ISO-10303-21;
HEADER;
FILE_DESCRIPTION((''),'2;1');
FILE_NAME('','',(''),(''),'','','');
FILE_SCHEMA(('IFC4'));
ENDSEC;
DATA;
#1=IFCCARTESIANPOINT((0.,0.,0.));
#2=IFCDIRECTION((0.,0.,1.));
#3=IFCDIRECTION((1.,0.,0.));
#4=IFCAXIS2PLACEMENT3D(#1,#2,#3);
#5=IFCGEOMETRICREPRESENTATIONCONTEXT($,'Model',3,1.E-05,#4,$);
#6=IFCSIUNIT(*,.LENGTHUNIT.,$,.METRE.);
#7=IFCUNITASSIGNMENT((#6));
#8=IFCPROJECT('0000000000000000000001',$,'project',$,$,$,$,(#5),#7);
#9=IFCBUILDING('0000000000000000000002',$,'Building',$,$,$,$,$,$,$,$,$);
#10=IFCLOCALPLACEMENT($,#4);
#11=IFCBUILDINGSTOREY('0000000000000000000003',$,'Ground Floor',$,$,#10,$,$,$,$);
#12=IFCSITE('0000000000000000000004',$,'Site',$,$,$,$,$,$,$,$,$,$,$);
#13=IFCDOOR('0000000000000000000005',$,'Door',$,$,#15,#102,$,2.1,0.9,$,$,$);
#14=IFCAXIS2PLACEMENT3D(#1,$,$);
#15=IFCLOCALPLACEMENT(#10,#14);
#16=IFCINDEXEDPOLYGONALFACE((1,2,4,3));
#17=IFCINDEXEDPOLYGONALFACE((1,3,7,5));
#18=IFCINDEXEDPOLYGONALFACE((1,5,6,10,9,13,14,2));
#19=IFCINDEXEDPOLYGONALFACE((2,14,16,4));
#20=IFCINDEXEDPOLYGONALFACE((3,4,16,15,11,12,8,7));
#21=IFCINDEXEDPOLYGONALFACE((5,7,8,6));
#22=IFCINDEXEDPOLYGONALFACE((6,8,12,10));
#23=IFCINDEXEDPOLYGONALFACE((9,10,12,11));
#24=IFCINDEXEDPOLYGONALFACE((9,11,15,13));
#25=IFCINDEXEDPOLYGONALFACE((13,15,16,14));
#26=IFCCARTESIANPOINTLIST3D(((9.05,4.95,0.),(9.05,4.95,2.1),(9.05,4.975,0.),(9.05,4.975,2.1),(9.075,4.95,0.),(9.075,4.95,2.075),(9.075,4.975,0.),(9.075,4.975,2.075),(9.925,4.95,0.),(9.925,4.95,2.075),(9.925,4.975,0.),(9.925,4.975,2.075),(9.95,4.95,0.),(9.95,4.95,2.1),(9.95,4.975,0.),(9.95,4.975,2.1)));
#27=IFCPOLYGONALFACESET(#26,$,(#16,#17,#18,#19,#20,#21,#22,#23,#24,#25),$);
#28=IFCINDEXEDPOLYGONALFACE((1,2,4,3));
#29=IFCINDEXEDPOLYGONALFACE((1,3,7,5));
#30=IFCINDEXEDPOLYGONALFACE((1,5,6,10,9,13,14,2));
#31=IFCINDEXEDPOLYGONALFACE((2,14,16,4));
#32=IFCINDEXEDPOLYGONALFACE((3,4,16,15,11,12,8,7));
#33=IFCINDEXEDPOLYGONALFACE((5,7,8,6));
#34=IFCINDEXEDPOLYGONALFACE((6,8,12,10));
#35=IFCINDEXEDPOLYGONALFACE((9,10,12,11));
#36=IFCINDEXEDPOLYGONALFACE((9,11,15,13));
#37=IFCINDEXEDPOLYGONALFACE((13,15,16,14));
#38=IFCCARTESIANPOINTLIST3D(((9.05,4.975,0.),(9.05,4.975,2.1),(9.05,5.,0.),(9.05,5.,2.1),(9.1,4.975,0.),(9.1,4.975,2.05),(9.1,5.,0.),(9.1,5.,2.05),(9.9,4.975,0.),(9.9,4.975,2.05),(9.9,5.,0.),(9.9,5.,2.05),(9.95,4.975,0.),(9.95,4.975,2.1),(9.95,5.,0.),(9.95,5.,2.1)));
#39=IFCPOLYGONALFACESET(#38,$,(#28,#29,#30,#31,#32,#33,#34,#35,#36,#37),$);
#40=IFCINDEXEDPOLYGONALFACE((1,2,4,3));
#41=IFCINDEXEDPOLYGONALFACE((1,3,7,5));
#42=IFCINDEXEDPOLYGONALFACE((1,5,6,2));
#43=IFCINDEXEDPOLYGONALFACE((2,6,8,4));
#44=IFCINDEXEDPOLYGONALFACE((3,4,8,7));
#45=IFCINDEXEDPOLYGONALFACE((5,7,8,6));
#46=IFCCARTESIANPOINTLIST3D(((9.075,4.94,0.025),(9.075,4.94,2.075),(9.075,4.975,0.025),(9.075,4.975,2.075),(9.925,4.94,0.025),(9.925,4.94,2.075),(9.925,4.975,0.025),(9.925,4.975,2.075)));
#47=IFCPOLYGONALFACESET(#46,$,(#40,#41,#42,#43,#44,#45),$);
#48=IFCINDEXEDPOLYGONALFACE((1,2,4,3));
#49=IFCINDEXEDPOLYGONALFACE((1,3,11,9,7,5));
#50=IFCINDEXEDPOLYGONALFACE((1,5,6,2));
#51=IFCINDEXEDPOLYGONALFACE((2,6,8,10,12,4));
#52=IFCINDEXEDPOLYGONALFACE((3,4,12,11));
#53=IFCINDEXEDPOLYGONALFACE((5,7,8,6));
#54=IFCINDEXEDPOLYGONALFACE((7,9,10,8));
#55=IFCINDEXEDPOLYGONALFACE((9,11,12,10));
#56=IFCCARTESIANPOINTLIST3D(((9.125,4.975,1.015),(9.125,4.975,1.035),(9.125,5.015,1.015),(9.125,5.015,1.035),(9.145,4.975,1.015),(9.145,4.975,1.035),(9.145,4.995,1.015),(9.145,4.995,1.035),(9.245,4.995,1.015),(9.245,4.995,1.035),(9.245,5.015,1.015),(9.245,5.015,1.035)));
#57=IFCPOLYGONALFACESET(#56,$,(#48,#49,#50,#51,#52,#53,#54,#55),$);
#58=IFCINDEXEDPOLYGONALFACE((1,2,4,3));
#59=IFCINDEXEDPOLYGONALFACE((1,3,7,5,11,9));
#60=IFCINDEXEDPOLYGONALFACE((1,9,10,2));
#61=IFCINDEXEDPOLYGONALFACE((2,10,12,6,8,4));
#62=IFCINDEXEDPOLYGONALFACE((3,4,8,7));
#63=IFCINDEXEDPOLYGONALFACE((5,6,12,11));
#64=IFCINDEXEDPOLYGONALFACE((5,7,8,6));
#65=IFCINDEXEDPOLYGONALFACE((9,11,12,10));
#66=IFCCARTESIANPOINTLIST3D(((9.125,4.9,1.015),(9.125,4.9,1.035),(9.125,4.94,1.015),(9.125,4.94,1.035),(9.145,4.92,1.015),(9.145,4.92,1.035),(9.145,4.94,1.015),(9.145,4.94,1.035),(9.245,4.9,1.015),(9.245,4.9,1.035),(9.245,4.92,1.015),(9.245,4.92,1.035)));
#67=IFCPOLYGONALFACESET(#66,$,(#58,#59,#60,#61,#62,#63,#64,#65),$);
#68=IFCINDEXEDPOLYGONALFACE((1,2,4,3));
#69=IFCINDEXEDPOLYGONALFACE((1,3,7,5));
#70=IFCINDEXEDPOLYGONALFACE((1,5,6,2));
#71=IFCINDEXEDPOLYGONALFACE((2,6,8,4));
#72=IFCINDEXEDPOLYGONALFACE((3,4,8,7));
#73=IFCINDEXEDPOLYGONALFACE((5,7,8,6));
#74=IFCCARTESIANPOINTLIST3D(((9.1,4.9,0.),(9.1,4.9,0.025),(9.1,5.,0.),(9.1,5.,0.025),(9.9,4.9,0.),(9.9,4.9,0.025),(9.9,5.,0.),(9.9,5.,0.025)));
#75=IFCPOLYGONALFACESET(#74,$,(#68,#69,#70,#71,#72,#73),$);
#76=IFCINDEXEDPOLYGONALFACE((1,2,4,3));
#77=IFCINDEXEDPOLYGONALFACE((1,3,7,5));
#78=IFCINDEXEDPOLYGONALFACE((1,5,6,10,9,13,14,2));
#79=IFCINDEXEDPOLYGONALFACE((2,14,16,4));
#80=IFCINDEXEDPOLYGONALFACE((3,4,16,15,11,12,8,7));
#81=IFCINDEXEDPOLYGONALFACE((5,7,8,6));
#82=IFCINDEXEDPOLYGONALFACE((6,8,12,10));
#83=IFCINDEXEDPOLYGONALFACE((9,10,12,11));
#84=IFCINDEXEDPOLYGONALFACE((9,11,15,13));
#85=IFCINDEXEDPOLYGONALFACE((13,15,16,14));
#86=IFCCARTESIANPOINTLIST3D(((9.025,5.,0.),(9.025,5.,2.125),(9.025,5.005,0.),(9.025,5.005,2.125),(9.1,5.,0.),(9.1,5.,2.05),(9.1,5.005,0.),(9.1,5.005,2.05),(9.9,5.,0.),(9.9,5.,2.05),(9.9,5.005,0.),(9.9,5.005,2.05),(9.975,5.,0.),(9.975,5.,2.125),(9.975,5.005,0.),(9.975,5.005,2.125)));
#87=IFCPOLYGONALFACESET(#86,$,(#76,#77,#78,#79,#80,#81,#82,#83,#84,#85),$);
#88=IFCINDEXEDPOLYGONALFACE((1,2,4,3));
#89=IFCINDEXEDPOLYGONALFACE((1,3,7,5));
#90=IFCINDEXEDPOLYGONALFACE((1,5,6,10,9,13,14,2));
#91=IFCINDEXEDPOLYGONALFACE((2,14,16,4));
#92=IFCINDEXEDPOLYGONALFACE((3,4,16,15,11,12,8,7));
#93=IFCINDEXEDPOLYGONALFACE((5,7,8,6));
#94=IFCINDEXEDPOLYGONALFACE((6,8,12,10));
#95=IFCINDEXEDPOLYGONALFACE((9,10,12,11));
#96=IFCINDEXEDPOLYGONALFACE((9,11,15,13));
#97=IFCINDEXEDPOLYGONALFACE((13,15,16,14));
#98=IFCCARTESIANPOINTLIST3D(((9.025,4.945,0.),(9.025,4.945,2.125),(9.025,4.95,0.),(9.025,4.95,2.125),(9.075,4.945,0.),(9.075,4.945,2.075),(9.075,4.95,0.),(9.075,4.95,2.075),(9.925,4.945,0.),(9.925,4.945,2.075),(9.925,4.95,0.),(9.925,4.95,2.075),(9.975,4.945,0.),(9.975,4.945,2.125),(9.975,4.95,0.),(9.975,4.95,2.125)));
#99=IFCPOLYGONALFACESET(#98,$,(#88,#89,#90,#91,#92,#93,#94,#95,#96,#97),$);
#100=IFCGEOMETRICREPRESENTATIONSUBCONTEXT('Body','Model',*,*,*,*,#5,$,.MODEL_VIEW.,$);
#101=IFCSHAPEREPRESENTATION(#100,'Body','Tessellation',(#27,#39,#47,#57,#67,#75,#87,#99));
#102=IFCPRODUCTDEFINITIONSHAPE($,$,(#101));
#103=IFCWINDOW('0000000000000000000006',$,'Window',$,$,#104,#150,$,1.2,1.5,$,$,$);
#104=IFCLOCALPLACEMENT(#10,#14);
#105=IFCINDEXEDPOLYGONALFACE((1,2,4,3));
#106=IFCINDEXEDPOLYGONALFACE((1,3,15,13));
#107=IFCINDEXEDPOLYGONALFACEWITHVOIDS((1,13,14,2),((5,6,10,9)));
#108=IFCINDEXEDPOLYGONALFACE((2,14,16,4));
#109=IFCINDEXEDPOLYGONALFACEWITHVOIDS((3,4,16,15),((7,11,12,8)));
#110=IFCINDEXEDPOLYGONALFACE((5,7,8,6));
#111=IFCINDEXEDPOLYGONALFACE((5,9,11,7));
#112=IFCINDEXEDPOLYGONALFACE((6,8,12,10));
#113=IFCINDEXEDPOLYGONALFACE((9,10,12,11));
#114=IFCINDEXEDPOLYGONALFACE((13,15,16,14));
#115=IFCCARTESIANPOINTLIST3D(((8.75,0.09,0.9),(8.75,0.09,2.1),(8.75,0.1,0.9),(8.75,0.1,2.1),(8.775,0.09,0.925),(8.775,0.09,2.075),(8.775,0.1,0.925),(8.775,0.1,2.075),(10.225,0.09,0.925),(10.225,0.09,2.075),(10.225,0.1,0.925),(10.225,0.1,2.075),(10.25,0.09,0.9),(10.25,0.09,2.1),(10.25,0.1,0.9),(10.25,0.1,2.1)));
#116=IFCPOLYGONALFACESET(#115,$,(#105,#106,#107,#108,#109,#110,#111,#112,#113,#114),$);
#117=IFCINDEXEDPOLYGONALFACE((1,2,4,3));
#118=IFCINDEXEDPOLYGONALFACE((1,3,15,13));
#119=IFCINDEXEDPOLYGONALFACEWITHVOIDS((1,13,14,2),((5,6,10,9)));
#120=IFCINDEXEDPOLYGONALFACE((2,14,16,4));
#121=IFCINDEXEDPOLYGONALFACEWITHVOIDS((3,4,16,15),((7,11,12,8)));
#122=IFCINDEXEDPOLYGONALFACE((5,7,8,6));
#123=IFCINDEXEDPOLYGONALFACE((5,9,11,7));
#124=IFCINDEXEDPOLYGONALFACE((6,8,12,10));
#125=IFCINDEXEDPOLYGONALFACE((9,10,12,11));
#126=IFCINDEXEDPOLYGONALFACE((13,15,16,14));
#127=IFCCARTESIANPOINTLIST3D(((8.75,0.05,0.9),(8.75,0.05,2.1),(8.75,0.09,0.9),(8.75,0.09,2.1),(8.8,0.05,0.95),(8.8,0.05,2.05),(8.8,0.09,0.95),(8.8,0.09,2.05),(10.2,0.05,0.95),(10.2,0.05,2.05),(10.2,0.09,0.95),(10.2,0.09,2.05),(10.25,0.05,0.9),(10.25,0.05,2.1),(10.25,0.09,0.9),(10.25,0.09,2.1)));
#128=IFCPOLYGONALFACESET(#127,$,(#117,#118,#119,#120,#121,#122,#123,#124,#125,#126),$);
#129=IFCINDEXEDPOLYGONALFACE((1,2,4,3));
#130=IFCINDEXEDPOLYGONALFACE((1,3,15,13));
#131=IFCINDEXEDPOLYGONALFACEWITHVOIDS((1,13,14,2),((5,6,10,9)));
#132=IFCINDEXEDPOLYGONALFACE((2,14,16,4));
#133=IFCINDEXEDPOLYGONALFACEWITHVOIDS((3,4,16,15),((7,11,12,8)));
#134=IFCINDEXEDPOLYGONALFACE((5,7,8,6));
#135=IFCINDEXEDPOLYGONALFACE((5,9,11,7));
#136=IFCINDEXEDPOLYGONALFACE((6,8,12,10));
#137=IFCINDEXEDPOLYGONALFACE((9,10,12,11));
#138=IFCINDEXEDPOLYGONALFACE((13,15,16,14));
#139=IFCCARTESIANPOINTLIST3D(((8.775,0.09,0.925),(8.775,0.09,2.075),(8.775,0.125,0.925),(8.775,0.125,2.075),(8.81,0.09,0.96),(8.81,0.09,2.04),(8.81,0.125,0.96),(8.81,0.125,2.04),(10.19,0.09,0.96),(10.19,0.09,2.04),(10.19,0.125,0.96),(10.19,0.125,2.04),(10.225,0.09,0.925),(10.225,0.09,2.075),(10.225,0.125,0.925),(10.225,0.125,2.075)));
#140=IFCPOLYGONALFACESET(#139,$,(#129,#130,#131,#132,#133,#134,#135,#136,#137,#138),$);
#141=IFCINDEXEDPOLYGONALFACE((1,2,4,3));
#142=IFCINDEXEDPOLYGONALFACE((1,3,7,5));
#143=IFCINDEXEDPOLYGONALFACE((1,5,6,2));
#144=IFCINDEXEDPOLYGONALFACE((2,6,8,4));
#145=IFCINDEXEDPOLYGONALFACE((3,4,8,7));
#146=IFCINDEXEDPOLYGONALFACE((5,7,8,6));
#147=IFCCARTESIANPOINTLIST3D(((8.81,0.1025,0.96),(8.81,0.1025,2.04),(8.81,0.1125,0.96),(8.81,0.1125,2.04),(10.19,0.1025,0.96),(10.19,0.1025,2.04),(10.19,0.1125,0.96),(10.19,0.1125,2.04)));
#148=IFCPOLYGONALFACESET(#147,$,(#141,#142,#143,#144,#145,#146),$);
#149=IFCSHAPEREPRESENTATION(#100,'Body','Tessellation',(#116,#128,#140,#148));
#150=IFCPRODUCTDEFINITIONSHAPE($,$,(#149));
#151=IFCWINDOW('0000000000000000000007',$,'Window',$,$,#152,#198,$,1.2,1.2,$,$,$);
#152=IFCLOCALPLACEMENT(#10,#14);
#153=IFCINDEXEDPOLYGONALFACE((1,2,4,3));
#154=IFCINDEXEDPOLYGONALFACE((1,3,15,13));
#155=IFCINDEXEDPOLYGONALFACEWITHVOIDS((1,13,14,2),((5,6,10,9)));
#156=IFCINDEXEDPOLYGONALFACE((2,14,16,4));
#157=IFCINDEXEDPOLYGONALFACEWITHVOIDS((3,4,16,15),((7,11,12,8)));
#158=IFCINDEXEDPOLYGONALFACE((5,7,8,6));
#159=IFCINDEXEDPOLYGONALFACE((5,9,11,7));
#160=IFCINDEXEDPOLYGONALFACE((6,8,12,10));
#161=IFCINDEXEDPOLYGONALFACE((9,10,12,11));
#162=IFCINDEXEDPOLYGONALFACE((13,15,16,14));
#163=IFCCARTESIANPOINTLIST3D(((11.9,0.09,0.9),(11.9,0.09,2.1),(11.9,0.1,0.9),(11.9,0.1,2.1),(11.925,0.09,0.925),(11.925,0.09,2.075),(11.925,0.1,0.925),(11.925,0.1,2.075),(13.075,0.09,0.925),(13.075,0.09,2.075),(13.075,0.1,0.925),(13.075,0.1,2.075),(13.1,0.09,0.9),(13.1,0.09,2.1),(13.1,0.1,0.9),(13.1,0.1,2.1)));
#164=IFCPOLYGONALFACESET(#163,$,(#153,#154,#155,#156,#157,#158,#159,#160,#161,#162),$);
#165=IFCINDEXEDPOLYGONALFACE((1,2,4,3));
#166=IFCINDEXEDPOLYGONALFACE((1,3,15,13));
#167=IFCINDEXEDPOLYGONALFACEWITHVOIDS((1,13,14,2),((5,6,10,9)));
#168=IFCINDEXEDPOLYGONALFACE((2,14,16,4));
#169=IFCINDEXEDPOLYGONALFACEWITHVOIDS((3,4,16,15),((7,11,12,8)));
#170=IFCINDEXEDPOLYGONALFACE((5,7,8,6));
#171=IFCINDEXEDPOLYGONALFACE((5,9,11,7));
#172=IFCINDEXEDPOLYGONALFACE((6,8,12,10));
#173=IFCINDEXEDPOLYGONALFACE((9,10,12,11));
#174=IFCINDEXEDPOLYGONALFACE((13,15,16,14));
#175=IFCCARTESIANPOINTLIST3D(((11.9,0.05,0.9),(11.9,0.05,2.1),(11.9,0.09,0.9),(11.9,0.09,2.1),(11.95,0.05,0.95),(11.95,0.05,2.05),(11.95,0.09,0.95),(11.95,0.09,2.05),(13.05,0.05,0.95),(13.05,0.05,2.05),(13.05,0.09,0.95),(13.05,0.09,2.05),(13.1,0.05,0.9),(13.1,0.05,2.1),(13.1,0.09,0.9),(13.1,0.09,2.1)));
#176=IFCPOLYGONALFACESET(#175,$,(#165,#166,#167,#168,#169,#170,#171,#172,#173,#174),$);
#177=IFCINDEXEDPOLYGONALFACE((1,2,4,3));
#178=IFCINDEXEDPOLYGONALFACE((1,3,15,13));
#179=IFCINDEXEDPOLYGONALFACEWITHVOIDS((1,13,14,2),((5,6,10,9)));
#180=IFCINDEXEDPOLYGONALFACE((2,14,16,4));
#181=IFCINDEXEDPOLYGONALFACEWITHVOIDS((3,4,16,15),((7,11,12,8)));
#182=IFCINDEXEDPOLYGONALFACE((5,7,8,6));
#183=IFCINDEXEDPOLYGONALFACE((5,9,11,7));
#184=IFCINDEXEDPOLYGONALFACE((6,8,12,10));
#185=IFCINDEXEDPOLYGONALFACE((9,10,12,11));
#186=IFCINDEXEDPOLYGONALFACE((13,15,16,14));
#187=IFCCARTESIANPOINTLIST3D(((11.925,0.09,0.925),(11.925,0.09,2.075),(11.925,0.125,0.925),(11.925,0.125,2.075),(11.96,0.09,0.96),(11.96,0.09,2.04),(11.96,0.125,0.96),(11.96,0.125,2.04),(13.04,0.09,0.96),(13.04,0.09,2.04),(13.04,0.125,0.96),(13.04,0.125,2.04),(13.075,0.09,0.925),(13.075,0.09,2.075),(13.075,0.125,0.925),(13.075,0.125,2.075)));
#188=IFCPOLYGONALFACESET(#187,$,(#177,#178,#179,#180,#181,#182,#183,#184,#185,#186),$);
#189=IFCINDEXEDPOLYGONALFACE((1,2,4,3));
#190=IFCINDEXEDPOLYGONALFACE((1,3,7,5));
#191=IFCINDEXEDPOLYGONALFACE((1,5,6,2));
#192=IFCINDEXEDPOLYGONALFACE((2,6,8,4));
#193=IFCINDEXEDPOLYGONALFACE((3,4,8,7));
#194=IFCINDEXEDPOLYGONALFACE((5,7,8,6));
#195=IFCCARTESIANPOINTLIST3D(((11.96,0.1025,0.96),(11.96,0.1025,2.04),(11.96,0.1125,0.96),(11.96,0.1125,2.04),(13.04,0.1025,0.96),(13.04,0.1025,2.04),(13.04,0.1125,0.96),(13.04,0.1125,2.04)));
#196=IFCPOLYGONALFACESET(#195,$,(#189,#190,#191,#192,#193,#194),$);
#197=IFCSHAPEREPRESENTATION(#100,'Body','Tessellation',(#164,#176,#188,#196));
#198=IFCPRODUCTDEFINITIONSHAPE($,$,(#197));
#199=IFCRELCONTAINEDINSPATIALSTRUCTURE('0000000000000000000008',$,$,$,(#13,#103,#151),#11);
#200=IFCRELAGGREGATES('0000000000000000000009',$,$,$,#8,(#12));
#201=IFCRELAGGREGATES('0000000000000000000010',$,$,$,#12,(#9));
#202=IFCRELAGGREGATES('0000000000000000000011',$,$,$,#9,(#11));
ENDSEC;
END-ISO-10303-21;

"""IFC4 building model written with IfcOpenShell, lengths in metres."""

from ifc_helpers import new_model, si_unit, frame, origin_with_axes, place, context, subcontext, project, spatial, line, indexed_curve, outline, extrude, element, save


model = new_model("IFC4")

# Units and contexts
model_context = context("Model", 3, precision=1e-05, world=origin_with_axes())
body_context = subcontext(model_context, "Body", "Model", "MODEL_VIEW")
ifc_project = project(units=[si_unit("LENGTHUNIT", "METRE")], contexts=[model_context])

# Site, building, storey
site = spatial("IfcSite", under=ifc_project, Name="Site")
building = spatial("IfcBuilding", under=site, Name="Building")
storey_placement = place(None, origin_with_axes())
storey = spatial("IfcBuildingStorey", under=building, at=storey_placement, Name="Ground Floor")

# Door
door_1_placement = place(storey_placement, frame((9.95, 5.0, 0.0), z_axis=(0.0, 0.0, 1.0), x_axis=(-1.0, 0.0, 0.0)))
element("IfcDoor", 1, at=door_1_placement, inside=storey, Name="Door", OverallHeight=2.1, OverallWidth=0.9, context=body_context, shape_type="SweptSolid", body=[
    extrude(outline(indexed_curve([(0.0, 0.0), (0.0, 2.1), (0.9, 2.1), (0.9, 0.0), (0.875, 0.0), (0.875, 2.075), (0.025, 2.075), (0.025, 0.0)], segments=[line(1, 2, 3, 4, 5, 6, 7, 8, 1)])), frame((0.0, 0.025, 0.0), z_axis=(0.0, -1.0, 0.0), x_axis=(1.0, 0.0, 0.0)), (0.0, 0.0, -1.0), 0.025),
    extrude(outline(indexed_curve([(0.0, 0.0), (0.0, 2.1), (0.9, 2.1), (0.9, 0.0), (0.85, 0.0), (0.85, 2.05), (0.05, 2.05), (0.05, 0.0)], segments=[line(1, 2, 3, 4, 5, 6, 7, 8, 1)])), frame((0.0, 0.0, 0.0), z_axis=(0.0, -1.0, 0.0), x_axis=(1.0, 0.0, 0.0)), (0.0, 0.0, -1.0), 0.025),
    extrude(outline(indexed_curve([(0.0, 0.0), (0.85, 0.0), (0.85, 0.035), (0.0, 0.035)], segments=[line(1, 2, 3, 4, 1)])), frame((0.025, 0.025, 0.025), z_axis=(0.0, 0.0, 1.0), x_axis=(1.0, 0.0, 0.0)), (0.0, 0.0, 1.0), 2.05),
    extrude(outline(indexed_curve([(0.0, 0.0), (0.0, -0.04), (-0.12, -0.04), (-0.12, -0.02), (-0.02, -0.02), (-0.02, 0.0)], segments=[line(1, 2, 3, 4, 5, 6, 1)])), frame((0.825, 0.025, 1.015), z_axis=(0.0, 0.0, 1.0), x_axis=(1.0, 0.0, 0.0)), (0.0, 0.0, 1.0), 0.02),
    extrude(outline(indexed_curve([(0.0, 0.0), (0.0, 0.04), (-0.12, 0.04), (-0.12, 0.02), (-0.02, 0.02), (-0.02, 0.0)], segments=[line(1, 2, 3, 4, 5, 6, 1)])), frame((0.825, 0.06, 1.015), z_axis=(0.0, 0.0, 1.0), x_axis=(1.0, 0.0, 0.0)), (0.0, 0.0, 1.0), 0.02),
    extrude(outline(indexed_curve([(0.0, 0.0), (0.8, 0.0), (0.8, 0.1), (0.0, 0.1)], segments=[line(1, 2, 3, 4, 1)])), frame((0.05, 0.0, 0.0), z_axis=(0.0, 0.0, 1.0), x_axis=(1.0, 0.0, 0.0)), (0.0, 0.0, 1.0), 0.025),
    extrude(outline(indexed_curve([(0.0, 0.0), (0.0, 2.125), (0.95, 2.125), (0.95, 0.0), (0.875, 0.0), (0.875, 2.05), (0.075, 2.05), (0.075, 0.0)], segments=[line(1, 2, 3, 4, 5, 6, 7, 8, 1)])), frame((-0.025, -0.005, 0.0), z_axis=(0.0, -1.0, 0.0), x_axis=(1.0, 0.0, 0.0)), (0.0, 0.0, -1.0), 0.005),
    extrude(outline(indexed_curve([(0.0, 0.0), (0.0, 2.125), (0.95, 2.125), (0.95, 0.0), (0.9, 0.0), (0.9, 2.075), (0.05, 2.075), (0.05, 0.0)], segments=[line(1, 2, 3, 4, 5, 6, 7, 8, 1)])), frame((-0.025, 0.05, 0.0), z_axis=(0.0, -1.0, 0.0), x_axis=(1.0, 0.0, 0.0)), (0.0, 0.0, -1.0), 0.005),
])

# Windows
window_placement = place(storey_placement, frame((8.75, 0.0, 0.9), z_axis=(0.0, 0.0, 1.0), x_axis=(1.0, 0.0, 0.0)))
element("IfcWindow", 2, at=window_placement, inside=storey, Name="Window", OverallHeight=1.2, OverallWidth=1.5, context=body_context, shape_type="SweptSolid", body=[
    extrude(outline(indexed_curve([(0.0, 0.0), (1.5, 0.0), (1.5, 1.2), (0.0, 1.2)], segments=[line(1, 2, 3, 4, 1)]), holes=[indexed_curve([(0.025, 0.025), (1.475, 0.025), (1.475, 1.175), (0.025, 1.175)], segments=[line(1, 2, 3, 4, 1)])]), frame((0.0, 0.09, 0.0), z_axis=(0.0, -1.0, 0.0), x_axis=(1.0, 0.0, 0.0)), (0.0, 0.0, -1.0), 0.01),
    extrude(outline(indexed_curve([(0.0, 0.0), (1.5, 0.0), (1.5, 1.2), (0.0, 1.2)], segments=[line(1, 2, 3, 4, 1)]), holes=[indexed_curve([(0.05, 0.05), (1.45, 0.05), (1.45, 1.15), (0.05, 1.15)], segments=[line(1, 2, 3, 4, 1)])]), frame((0.0, 0.05, 0.0), z_axis=(0.0, -1.0, 0.0), x_axis=(1.0, 0.0, 0.0)), (0.0, 0.0, -1.0), 0.04),
    extrude(outline(indexed_curve([(0.0, 0.0), (1.45, 0.0), (1.45, 1.15), (0.0, 1.15)], segments=[line(1, 2, 3, 4, 1)]), holes=[indexed_curve([(0.035, 0.035), (1.415, 0.035), (1.415, 1.115), (0.035, 1.115)], segments=[line(1, 2, 3, 4, 1)])]), frame((0.025, 0.09, 0.025), z_axis=(0.0, -1.0, 0.0), x_axis=(1.0, 0.0, 0.0)), (0.0, 0.0, -1.0), 0.035),
    extrude(outline(indexed_curve([(0.035, 0.035), (1.415, 0.035), (1.415, 1.115), (0.035, 1.115)], segments=[line(1, 2, 3, 4, 1)])), frame((0.025, 0.1025, 0.025), z_axis=(0.0, -1.0, 0.0), x_axis=(1.0, 0.0, 0.0)), (0.0, 0.0, -1.0), 0.01),
])
for number, where, z_axis, x_axis, name in (
    (3, (11.9, 0.0, 0.9), (0.0, 0.0, 1.0), (1.0, 0.0, 0.0), "Window"),
):
    element("IfcWindow", number, at=place(storey_placement, frame(where, z_axis=z_axis, x_axis=x_axis)), inside=storey, Name=name, OverallHeight=1.2, OverallWidth=1.2, context=body_context, shape_type="SweptSolid", body=[
        extrude(outline(indexed_curve([(0.0, 0.0), (1.2, 0.0), (1.2, 1.2), (0.0, 1.2)], segments=[line(1, 2, 3, 4, 1)]), holes=[indexed_curve([(0.025, 0.025), (1.175, 0.025), (1.175, 1.175), (0.025, 1.175)], segments=[line(1, 2, 3, 4, 1)])]), frame((0.0, 0.09, 0.0), z_axis=(0.0, -1.0, 0.0), x_axis=(1.0, 0.0, 0.0)), (0.0, 0.0, -1.0), 0.01),
        extrude(outline(indexed_curve([(0.0, 0.0), (1.2, 0.0), (1.2, 1.2), (0.0, 1.2)], segments=[line(1, 2, 3, 4, 1)]), holes=[indexed_curve([(0.05, 0.05), (1.15, 0.05), (1.15, 1.15), (0.05, 1.15)], segments=[line(1, 2, 3, 4, 1)])]), frame((0.0, 0.05, 0.0), z_axis=(0.0, -1.0, 0.0), x_axis=(1.0, 0.0, 0.0)), (0.0, 0.0, -1.0), 0.04),
        extrude(outline(indexed_curve([(0.0, 0.0), (1.15, 0.0), (1.15, 1.15), (0.0, 1.15)], segments=[line(1, 2, 3, 4, 1)]), holes=[indexed_curve([(0.035, 0.035), (1.115, 0.035), (1.115, 1.115), (0.035, 1.115)], segments=[line(1, 2, 3, 4, 1)])]), frame((0.025, 0.09, 0.025), z_axis=(0.0, -1.0, 0.0), x_axis=(1.0, 0.0, 0.0)), (0.0, 0.0, -1.0), 0.035),
        extrude(outline(indexed_curve([(0.035, 0.035), (1.115, 0.035), (1.115, 1.115), (0.035, 1.115)], segments=[line(1, 2, 3, 4, 1)])), frame((0.025, 0.1025, 0.025), z_axis=(0.0, -1.0, 0.0), x_axis=(1.0, 0.0, 0.0)), (0.0, 0.0, -1.0), 0.01),
    ])

save(model, "model.ifc")
